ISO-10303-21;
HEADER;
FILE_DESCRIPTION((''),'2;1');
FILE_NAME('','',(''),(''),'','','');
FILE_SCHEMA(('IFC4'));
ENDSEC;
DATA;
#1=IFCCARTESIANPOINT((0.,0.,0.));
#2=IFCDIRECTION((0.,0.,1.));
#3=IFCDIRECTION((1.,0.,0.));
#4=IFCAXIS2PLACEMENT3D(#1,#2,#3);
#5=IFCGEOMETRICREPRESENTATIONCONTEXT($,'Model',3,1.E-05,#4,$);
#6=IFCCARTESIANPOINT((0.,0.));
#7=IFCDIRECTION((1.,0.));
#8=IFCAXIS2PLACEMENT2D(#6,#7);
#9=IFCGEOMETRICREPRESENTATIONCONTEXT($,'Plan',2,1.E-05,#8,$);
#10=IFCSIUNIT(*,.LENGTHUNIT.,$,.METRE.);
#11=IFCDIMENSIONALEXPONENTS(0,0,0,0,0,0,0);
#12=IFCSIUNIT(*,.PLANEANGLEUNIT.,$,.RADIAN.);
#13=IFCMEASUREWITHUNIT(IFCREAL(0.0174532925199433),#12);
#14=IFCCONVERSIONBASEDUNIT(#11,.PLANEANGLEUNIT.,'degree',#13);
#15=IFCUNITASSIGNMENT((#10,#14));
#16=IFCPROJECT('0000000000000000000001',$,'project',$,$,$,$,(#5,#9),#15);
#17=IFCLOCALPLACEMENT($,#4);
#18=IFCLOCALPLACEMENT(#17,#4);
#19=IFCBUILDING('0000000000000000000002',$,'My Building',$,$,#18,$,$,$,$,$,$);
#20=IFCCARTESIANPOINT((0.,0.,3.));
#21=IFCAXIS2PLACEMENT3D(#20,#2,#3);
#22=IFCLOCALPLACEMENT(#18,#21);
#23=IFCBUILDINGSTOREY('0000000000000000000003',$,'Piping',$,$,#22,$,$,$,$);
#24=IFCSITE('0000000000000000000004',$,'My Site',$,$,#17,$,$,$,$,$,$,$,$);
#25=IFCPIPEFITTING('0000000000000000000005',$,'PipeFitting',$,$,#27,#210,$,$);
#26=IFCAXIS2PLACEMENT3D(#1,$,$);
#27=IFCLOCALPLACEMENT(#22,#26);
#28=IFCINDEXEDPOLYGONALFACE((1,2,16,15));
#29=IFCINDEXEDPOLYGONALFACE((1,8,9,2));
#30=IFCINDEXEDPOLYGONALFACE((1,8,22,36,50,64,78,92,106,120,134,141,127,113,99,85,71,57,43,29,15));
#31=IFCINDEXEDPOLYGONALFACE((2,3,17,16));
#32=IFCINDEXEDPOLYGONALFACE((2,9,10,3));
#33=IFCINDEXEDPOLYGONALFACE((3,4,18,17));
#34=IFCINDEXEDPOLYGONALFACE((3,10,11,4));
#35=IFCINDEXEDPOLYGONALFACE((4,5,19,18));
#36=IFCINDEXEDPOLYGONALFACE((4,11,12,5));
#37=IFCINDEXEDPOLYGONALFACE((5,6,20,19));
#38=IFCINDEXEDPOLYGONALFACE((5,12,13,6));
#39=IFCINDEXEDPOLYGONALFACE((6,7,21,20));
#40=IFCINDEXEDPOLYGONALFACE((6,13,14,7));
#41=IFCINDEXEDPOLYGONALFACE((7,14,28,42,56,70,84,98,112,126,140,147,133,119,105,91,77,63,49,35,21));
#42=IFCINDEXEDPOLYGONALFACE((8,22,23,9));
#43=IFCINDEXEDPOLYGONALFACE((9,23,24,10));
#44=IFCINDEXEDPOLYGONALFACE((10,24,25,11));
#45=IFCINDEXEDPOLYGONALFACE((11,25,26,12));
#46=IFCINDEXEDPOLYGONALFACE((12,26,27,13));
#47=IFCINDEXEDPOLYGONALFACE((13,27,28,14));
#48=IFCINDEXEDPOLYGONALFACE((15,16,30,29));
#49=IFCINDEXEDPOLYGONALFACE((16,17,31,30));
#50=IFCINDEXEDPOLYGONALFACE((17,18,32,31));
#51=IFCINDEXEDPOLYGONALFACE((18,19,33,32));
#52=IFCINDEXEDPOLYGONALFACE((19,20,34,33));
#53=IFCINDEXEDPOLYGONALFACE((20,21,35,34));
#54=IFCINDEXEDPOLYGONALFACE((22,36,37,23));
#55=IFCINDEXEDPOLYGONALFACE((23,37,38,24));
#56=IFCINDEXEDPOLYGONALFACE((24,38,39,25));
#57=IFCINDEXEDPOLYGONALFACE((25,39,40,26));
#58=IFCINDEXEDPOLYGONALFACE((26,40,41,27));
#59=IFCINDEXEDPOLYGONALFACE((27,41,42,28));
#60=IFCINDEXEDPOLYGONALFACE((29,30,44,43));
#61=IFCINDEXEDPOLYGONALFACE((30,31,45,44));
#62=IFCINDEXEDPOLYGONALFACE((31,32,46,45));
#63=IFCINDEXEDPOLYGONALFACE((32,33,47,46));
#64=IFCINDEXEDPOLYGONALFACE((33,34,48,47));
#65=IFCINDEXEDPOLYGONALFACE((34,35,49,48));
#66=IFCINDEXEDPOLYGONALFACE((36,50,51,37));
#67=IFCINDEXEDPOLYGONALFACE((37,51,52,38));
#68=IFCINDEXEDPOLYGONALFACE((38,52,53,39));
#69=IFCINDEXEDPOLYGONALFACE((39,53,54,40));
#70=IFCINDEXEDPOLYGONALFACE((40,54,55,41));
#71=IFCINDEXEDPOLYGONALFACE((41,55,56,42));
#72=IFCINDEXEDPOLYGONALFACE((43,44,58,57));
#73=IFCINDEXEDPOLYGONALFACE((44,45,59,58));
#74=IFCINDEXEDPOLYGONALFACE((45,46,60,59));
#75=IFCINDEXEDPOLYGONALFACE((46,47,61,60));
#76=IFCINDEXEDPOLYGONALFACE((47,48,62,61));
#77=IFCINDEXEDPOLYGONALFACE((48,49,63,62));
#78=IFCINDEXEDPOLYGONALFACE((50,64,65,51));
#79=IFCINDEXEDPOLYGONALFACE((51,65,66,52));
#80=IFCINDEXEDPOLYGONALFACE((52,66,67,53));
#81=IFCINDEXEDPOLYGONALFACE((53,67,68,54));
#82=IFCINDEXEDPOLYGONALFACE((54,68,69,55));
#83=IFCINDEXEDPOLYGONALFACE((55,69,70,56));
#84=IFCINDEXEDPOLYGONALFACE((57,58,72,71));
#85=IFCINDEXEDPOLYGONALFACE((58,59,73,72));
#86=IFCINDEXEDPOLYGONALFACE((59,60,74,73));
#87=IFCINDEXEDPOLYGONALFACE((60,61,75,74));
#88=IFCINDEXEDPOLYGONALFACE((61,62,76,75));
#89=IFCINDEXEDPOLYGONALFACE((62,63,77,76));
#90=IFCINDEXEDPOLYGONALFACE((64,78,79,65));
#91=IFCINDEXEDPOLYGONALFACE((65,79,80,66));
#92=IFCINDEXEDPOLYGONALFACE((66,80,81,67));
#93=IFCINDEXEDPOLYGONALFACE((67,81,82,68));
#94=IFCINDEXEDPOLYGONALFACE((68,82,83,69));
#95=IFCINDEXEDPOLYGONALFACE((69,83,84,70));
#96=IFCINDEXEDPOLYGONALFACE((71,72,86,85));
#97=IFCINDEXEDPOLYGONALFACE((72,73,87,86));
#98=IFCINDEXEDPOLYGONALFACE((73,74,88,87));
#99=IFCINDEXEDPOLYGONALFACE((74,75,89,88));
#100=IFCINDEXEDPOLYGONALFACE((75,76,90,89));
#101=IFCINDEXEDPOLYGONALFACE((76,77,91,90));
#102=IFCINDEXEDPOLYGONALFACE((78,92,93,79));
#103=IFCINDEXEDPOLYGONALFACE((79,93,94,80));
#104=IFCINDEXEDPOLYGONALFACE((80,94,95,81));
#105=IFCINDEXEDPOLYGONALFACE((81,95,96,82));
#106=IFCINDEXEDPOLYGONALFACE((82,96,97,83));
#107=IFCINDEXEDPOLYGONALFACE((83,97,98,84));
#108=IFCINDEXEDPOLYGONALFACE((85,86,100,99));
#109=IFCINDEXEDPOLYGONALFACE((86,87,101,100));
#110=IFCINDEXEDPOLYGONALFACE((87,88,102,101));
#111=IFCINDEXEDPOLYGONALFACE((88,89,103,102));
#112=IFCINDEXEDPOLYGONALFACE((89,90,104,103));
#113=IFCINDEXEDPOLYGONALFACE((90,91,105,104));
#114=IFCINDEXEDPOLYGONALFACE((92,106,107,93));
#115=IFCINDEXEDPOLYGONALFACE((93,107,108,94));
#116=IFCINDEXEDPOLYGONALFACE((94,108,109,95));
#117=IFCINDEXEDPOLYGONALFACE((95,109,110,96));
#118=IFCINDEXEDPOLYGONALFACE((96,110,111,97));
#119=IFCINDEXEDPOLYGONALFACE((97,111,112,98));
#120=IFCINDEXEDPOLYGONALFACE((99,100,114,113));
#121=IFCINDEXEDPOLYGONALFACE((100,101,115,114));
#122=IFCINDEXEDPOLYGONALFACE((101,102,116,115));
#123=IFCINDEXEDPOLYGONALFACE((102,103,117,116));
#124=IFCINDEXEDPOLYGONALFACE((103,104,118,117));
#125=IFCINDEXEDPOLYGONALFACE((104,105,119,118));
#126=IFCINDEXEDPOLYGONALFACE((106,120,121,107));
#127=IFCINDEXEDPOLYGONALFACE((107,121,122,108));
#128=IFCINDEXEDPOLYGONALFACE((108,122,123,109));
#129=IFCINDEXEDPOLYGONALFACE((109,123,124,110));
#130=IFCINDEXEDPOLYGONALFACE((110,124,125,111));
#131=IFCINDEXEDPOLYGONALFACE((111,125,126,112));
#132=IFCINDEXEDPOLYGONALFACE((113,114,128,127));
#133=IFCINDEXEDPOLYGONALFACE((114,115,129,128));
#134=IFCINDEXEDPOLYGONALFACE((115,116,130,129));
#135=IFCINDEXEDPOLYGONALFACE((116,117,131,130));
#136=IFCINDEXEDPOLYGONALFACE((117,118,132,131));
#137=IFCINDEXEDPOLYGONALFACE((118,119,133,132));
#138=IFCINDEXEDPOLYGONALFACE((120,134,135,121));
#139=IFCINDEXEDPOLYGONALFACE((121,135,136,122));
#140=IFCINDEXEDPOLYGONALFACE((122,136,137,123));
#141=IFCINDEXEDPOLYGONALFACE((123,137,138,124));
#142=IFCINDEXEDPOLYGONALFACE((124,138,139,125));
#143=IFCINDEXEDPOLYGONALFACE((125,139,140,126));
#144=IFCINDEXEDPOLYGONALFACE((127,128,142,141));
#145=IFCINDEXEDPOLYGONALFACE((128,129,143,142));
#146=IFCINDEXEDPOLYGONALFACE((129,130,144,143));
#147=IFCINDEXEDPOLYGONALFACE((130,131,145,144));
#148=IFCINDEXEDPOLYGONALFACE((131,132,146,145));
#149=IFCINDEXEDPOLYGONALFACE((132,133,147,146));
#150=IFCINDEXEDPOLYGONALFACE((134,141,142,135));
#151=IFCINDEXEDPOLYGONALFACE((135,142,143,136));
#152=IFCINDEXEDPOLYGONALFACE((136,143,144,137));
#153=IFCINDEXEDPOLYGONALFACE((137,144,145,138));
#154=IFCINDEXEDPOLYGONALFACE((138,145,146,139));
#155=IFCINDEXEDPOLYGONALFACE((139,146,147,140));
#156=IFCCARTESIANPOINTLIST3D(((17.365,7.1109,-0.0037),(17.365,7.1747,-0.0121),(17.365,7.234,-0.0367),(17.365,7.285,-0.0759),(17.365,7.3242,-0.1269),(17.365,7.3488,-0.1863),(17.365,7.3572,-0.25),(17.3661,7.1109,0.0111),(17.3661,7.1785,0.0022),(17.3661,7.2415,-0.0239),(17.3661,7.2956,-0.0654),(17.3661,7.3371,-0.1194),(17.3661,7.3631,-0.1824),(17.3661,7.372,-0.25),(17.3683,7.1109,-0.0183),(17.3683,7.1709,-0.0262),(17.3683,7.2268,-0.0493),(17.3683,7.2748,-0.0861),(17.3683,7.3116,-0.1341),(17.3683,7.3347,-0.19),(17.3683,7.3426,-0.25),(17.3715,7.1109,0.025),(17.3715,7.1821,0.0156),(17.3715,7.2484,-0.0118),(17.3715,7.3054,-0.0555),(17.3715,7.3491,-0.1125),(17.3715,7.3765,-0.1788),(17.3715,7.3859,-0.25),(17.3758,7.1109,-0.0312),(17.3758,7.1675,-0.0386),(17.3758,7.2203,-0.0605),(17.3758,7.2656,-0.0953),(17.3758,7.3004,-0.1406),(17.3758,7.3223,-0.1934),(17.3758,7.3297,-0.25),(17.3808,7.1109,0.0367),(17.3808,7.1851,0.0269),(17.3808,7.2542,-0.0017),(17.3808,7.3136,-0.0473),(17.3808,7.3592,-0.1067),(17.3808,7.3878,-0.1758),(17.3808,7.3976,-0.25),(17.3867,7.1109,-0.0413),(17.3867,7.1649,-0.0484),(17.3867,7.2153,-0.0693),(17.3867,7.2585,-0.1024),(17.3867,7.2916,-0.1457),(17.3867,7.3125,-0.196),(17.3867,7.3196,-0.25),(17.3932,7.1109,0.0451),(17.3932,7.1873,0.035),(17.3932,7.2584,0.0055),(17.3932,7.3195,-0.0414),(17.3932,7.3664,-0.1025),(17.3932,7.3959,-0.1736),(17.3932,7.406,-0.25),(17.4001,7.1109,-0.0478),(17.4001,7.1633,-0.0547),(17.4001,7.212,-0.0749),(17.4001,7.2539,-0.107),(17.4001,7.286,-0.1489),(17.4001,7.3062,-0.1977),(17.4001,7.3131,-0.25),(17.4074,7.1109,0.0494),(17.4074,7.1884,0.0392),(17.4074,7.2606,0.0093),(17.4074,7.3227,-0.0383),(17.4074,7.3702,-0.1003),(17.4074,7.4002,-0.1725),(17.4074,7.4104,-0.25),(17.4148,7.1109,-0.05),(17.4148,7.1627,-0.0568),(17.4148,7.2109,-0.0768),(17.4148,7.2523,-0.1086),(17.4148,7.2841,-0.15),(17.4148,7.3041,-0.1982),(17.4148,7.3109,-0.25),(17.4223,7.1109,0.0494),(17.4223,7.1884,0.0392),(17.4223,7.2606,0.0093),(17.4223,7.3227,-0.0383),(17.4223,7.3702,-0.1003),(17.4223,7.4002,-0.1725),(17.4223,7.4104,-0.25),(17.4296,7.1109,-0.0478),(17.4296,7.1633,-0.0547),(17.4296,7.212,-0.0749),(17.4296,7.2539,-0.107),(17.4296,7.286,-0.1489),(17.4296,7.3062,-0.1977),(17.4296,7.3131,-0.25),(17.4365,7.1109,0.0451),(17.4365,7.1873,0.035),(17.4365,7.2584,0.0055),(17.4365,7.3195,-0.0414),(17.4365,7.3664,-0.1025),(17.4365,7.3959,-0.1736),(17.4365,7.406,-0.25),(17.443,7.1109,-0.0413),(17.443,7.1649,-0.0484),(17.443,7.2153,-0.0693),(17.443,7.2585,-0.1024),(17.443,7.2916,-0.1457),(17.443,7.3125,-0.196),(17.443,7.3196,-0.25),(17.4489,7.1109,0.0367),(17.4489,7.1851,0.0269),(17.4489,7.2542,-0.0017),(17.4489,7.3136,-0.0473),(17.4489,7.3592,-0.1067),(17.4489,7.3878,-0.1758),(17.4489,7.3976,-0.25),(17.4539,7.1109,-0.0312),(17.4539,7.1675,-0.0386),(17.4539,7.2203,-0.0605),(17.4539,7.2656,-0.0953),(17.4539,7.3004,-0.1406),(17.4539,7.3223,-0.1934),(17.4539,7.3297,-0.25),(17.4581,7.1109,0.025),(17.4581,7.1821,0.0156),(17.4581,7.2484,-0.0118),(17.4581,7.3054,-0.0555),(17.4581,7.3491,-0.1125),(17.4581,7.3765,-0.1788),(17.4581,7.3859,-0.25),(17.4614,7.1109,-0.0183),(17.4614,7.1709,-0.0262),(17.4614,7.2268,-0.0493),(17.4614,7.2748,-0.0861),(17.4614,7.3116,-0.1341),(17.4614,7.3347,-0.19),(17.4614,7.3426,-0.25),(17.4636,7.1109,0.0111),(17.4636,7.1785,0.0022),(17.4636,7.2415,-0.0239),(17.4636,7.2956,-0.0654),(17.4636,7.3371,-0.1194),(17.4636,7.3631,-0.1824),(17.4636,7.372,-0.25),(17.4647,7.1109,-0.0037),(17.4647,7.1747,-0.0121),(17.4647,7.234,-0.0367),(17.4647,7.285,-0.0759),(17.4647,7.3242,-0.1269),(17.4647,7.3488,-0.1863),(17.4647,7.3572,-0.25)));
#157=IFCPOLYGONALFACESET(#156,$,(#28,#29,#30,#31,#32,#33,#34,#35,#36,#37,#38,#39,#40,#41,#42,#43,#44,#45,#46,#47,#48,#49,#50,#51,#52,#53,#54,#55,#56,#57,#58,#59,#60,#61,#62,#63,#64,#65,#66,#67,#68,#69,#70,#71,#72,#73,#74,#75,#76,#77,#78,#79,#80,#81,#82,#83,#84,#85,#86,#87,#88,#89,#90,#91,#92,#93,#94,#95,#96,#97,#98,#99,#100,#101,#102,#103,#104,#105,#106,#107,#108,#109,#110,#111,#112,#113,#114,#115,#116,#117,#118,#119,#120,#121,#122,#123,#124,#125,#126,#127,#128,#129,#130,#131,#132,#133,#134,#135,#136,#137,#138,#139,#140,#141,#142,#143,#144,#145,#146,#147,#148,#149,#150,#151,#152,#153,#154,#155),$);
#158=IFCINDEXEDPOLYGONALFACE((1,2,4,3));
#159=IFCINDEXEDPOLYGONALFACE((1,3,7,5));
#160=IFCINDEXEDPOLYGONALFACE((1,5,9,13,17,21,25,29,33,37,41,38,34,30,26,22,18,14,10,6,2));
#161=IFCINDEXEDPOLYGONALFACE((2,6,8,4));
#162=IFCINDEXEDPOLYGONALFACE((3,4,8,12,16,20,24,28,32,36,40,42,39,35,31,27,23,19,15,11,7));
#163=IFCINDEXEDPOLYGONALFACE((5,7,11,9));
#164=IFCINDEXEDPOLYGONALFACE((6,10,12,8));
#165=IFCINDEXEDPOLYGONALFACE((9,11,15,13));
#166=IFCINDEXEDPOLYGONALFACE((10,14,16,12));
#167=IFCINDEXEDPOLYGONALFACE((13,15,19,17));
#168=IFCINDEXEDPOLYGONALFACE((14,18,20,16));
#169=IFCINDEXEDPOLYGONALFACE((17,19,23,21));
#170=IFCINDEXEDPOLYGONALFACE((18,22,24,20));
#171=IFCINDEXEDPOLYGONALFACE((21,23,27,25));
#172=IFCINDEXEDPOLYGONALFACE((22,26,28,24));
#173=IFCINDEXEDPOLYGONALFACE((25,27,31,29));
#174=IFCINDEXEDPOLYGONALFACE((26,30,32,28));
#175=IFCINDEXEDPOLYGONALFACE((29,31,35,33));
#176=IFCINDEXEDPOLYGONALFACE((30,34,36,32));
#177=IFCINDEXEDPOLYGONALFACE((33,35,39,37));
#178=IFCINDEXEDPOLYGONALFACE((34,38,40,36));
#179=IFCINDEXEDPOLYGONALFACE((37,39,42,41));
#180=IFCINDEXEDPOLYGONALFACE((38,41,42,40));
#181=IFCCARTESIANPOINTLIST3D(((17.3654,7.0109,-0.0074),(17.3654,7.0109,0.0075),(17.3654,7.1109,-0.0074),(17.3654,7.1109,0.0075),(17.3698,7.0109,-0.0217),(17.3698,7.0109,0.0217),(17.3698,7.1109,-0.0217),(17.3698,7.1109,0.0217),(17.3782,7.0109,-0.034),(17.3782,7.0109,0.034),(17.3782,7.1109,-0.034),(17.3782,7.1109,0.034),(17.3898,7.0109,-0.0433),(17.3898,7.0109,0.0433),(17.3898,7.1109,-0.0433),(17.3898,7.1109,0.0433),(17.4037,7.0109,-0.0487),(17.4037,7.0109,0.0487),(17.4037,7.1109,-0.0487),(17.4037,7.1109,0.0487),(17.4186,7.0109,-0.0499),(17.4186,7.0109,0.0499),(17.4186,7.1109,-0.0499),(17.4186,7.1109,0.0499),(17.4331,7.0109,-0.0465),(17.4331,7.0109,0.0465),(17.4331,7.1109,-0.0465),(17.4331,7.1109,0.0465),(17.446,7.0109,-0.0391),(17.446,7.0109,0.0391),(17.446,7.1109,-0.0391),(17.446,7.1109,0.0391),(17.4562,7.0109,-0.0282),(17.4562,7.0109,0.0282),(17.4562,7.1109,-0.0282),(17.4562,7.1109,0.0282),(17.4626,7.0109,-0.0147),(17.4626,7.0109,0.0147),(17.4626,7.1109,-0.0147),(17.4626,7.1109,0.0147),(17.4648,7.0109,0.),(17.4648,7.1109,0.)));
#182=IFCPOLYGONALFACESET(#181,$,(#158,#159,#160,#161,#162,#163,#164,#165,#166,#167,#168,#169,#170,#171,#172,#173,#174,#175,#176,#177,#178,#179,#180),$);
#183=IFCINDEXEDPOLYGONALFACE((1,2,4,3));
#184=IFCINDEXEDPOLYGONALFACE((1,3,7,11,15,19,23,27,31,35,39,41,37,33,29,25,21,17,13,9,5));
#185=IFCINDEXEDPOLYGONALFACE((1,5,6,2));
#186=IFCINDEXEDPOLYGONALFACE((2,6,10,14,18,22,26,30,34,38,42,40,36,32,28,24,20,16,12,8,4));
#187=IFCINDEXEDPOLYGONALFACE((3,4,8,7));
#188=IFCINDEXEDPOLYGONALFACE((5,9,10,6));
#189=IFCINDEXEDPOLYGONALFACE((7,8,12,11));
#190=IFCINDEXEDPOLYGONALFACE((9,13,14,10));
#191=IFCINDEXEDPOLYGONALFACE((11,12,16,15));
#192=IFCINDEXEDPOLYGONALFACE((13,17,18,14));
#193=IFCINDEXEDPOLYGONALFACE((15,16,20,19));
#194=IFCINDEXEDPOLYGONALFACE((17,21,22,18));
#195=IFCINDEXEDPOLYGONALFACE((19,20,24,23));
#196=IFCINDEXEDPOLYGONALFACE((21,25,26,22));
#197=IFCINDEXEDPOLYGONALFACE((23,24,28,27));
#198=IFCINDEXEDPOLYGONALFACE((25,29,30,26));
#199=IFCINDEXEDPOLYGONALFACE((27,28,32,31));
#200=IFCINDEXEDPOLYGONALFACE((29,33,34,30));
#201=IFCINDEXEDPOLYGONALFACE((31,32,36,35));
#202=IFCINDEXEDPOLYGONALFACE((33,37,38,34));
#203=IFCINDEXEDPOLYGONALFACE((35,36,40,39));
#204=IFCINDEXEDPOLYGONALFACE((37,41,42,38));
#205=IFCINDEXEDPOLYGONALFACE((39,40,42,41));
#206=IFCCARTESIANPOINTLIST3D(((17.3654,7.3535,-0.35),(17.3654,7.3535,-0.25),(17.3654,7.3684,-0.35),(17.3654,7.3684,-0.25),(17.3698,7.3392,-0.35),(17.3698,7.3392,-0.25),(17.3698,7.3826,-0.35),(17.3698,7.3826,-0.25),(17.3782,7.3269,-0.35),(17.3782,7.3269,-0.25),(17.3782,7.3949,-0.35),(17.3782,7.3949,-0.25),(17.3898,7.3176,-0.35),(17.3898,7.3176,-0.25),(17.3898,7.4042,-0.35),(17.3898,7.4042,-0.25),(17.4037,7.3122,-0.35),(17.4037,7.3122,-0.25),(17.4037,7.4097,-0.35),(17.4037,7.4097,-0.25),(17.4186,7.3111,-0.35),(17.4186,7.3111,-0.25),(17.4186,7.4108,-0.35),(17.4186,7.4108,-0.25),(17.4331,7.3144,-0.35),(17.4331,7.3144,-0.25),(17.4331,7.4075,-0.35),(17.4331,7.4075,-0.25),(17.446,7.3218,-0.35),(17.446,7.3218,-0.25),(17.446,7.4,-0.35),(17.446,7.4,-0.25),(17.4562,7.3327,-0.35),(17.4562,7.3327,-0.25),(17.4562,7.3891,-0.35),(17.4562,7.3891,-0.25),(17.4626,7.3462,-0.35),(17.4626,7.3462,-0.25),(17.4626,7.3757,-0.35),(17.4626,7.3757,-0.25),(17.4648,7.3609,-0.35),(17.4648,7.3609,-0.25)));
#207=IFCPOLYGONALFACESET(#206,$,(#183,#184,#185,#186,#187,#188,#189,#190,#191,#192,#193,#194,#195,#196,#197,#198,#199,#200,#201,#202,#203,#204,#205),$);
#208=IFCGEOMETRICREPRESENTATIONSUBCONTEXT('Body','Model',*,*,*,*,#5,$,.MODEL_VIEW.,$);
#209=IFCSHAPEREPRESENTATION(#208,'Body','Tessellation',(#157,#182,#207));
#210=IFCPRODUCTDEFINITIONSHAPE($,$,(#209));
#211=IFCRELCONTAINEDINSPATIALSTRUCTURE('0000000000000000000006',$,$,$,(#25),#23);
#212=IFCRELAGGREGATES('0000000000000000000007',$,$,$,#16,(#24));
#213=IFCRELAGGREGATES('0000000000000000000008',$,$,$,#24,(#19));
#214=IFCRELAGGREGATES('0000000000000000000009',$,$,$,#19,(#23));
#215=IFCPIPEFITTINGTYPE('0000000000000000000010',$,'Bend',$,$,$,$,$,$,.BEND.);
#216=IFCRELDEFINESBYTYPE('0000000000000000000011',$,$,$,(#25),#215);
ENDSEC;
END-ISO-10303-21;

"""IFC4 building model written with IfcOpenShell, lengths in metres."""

from ifc_helpers import new_model, entity, si_unit, converted_unit, frame, origin_with_axes, origin_2d_with_axis, place, context, subcontext, project, spatial, circle, extrude, source, transform, mapped, type_object, type_shapes, element, save


model = new_model("IFC4")

# Units and contexts
model_context = context("Model", 3, precision=1e-05, world=origin_with_axes())
plan_context = context("Plan", 2, precision=1e-05, world=origin_2d_with_axis())
body_context = subcontext(model_context, "Body", "Model", "MODEL_VIEW")
ifc_project = project(units=[si_unit("LENGTHUNIT", "METRE"), converted_unit("PLANEANGLEUNIT", "degree", entity("IfcReal", 0.0174532925199433), si_unit("PLANEANGLEUNIT", "RADIAN"), dimensions=[0, 0, 0, 0, 0, 0, 0])], contexts=[model_context, plan_context])

# Site, building, storey
site_placement = place(None, origin_with_axes())
site = spatial("IfcSite", under=ifc_project, at=site_placement, Name="My Site")
building_placement = place(site_placement, origin_with_axes())
building = spatial("IfcBuilding", under=site, at=building_placement, Name="My Building")
storey_placement = place(building_placement, frame((0.0, 0.0, 3.0), z_axis=(0.0, 0.0, 1.0), x_axis=(1.0, 0.0, 0.0)))
storey = spatial("IfcBuildingStorey", under=building, at=storey_placement, Name="Piping")

# Pipe fitting
pipe_fitting_type = type_object("IfcPipeFittingType", Name="Bend", PredefinedType="BEND")
shared_shape = source(origin_with_axes(), body_context, "Body", "SolidModel", [
    entity("IfcSweptDiskSolid", entity("IfcIndexedPolyCurve", entity("IfcCartesianPointList3D", [[0.0, 0.0, -0.1], [0.0, -0.0732, -0.2768], [0.0, -0.25, -0.35]]), [entity("IfcArcIndex", [1, 2, 3])]), 0.05),
    extrude(circle(Radius=0.05), origin_with_axes(), (0.0, 0.0, -1.0), 0.1),
    extrude(circle(Radius=0.05), frame((0.0, -0.25, -0.35), z_axis=(0.0, -1.0, 0.0), x_axis=(1.0, 0.0, 0.0)), (0.0, 0.0, 1.0), 0.1),
])
type_shapes(pipe_fitting_type, [shared_shape])
for number, where, z_axis, x_axis, name in (
    (1, (17.4148, 7.0109, 0.0), (0.0, -1.0, 0.0), (1.0, 0.0, 0.0), "PipeFitting"),
):
    element("IfcPipeFitting", number, at=place(storey_placement, frame(where, z_axis=z_axis, x_axis=x_axis)), inside=storey, type_object=pipe_fitting_type, Name=name, context=body_context, shape_type="MappedRepresentation", body=[
        mapped(shared_shape, transform((0.0, 0.0, 0.0), x_axis=(1.0, 0.0, 0.0), y_axis=(0.0, 1.0, 0.0), z_axis=(0.0, 0.0, 1.0), scale=1.0)),
    ])

save(model, "model.ifc")
